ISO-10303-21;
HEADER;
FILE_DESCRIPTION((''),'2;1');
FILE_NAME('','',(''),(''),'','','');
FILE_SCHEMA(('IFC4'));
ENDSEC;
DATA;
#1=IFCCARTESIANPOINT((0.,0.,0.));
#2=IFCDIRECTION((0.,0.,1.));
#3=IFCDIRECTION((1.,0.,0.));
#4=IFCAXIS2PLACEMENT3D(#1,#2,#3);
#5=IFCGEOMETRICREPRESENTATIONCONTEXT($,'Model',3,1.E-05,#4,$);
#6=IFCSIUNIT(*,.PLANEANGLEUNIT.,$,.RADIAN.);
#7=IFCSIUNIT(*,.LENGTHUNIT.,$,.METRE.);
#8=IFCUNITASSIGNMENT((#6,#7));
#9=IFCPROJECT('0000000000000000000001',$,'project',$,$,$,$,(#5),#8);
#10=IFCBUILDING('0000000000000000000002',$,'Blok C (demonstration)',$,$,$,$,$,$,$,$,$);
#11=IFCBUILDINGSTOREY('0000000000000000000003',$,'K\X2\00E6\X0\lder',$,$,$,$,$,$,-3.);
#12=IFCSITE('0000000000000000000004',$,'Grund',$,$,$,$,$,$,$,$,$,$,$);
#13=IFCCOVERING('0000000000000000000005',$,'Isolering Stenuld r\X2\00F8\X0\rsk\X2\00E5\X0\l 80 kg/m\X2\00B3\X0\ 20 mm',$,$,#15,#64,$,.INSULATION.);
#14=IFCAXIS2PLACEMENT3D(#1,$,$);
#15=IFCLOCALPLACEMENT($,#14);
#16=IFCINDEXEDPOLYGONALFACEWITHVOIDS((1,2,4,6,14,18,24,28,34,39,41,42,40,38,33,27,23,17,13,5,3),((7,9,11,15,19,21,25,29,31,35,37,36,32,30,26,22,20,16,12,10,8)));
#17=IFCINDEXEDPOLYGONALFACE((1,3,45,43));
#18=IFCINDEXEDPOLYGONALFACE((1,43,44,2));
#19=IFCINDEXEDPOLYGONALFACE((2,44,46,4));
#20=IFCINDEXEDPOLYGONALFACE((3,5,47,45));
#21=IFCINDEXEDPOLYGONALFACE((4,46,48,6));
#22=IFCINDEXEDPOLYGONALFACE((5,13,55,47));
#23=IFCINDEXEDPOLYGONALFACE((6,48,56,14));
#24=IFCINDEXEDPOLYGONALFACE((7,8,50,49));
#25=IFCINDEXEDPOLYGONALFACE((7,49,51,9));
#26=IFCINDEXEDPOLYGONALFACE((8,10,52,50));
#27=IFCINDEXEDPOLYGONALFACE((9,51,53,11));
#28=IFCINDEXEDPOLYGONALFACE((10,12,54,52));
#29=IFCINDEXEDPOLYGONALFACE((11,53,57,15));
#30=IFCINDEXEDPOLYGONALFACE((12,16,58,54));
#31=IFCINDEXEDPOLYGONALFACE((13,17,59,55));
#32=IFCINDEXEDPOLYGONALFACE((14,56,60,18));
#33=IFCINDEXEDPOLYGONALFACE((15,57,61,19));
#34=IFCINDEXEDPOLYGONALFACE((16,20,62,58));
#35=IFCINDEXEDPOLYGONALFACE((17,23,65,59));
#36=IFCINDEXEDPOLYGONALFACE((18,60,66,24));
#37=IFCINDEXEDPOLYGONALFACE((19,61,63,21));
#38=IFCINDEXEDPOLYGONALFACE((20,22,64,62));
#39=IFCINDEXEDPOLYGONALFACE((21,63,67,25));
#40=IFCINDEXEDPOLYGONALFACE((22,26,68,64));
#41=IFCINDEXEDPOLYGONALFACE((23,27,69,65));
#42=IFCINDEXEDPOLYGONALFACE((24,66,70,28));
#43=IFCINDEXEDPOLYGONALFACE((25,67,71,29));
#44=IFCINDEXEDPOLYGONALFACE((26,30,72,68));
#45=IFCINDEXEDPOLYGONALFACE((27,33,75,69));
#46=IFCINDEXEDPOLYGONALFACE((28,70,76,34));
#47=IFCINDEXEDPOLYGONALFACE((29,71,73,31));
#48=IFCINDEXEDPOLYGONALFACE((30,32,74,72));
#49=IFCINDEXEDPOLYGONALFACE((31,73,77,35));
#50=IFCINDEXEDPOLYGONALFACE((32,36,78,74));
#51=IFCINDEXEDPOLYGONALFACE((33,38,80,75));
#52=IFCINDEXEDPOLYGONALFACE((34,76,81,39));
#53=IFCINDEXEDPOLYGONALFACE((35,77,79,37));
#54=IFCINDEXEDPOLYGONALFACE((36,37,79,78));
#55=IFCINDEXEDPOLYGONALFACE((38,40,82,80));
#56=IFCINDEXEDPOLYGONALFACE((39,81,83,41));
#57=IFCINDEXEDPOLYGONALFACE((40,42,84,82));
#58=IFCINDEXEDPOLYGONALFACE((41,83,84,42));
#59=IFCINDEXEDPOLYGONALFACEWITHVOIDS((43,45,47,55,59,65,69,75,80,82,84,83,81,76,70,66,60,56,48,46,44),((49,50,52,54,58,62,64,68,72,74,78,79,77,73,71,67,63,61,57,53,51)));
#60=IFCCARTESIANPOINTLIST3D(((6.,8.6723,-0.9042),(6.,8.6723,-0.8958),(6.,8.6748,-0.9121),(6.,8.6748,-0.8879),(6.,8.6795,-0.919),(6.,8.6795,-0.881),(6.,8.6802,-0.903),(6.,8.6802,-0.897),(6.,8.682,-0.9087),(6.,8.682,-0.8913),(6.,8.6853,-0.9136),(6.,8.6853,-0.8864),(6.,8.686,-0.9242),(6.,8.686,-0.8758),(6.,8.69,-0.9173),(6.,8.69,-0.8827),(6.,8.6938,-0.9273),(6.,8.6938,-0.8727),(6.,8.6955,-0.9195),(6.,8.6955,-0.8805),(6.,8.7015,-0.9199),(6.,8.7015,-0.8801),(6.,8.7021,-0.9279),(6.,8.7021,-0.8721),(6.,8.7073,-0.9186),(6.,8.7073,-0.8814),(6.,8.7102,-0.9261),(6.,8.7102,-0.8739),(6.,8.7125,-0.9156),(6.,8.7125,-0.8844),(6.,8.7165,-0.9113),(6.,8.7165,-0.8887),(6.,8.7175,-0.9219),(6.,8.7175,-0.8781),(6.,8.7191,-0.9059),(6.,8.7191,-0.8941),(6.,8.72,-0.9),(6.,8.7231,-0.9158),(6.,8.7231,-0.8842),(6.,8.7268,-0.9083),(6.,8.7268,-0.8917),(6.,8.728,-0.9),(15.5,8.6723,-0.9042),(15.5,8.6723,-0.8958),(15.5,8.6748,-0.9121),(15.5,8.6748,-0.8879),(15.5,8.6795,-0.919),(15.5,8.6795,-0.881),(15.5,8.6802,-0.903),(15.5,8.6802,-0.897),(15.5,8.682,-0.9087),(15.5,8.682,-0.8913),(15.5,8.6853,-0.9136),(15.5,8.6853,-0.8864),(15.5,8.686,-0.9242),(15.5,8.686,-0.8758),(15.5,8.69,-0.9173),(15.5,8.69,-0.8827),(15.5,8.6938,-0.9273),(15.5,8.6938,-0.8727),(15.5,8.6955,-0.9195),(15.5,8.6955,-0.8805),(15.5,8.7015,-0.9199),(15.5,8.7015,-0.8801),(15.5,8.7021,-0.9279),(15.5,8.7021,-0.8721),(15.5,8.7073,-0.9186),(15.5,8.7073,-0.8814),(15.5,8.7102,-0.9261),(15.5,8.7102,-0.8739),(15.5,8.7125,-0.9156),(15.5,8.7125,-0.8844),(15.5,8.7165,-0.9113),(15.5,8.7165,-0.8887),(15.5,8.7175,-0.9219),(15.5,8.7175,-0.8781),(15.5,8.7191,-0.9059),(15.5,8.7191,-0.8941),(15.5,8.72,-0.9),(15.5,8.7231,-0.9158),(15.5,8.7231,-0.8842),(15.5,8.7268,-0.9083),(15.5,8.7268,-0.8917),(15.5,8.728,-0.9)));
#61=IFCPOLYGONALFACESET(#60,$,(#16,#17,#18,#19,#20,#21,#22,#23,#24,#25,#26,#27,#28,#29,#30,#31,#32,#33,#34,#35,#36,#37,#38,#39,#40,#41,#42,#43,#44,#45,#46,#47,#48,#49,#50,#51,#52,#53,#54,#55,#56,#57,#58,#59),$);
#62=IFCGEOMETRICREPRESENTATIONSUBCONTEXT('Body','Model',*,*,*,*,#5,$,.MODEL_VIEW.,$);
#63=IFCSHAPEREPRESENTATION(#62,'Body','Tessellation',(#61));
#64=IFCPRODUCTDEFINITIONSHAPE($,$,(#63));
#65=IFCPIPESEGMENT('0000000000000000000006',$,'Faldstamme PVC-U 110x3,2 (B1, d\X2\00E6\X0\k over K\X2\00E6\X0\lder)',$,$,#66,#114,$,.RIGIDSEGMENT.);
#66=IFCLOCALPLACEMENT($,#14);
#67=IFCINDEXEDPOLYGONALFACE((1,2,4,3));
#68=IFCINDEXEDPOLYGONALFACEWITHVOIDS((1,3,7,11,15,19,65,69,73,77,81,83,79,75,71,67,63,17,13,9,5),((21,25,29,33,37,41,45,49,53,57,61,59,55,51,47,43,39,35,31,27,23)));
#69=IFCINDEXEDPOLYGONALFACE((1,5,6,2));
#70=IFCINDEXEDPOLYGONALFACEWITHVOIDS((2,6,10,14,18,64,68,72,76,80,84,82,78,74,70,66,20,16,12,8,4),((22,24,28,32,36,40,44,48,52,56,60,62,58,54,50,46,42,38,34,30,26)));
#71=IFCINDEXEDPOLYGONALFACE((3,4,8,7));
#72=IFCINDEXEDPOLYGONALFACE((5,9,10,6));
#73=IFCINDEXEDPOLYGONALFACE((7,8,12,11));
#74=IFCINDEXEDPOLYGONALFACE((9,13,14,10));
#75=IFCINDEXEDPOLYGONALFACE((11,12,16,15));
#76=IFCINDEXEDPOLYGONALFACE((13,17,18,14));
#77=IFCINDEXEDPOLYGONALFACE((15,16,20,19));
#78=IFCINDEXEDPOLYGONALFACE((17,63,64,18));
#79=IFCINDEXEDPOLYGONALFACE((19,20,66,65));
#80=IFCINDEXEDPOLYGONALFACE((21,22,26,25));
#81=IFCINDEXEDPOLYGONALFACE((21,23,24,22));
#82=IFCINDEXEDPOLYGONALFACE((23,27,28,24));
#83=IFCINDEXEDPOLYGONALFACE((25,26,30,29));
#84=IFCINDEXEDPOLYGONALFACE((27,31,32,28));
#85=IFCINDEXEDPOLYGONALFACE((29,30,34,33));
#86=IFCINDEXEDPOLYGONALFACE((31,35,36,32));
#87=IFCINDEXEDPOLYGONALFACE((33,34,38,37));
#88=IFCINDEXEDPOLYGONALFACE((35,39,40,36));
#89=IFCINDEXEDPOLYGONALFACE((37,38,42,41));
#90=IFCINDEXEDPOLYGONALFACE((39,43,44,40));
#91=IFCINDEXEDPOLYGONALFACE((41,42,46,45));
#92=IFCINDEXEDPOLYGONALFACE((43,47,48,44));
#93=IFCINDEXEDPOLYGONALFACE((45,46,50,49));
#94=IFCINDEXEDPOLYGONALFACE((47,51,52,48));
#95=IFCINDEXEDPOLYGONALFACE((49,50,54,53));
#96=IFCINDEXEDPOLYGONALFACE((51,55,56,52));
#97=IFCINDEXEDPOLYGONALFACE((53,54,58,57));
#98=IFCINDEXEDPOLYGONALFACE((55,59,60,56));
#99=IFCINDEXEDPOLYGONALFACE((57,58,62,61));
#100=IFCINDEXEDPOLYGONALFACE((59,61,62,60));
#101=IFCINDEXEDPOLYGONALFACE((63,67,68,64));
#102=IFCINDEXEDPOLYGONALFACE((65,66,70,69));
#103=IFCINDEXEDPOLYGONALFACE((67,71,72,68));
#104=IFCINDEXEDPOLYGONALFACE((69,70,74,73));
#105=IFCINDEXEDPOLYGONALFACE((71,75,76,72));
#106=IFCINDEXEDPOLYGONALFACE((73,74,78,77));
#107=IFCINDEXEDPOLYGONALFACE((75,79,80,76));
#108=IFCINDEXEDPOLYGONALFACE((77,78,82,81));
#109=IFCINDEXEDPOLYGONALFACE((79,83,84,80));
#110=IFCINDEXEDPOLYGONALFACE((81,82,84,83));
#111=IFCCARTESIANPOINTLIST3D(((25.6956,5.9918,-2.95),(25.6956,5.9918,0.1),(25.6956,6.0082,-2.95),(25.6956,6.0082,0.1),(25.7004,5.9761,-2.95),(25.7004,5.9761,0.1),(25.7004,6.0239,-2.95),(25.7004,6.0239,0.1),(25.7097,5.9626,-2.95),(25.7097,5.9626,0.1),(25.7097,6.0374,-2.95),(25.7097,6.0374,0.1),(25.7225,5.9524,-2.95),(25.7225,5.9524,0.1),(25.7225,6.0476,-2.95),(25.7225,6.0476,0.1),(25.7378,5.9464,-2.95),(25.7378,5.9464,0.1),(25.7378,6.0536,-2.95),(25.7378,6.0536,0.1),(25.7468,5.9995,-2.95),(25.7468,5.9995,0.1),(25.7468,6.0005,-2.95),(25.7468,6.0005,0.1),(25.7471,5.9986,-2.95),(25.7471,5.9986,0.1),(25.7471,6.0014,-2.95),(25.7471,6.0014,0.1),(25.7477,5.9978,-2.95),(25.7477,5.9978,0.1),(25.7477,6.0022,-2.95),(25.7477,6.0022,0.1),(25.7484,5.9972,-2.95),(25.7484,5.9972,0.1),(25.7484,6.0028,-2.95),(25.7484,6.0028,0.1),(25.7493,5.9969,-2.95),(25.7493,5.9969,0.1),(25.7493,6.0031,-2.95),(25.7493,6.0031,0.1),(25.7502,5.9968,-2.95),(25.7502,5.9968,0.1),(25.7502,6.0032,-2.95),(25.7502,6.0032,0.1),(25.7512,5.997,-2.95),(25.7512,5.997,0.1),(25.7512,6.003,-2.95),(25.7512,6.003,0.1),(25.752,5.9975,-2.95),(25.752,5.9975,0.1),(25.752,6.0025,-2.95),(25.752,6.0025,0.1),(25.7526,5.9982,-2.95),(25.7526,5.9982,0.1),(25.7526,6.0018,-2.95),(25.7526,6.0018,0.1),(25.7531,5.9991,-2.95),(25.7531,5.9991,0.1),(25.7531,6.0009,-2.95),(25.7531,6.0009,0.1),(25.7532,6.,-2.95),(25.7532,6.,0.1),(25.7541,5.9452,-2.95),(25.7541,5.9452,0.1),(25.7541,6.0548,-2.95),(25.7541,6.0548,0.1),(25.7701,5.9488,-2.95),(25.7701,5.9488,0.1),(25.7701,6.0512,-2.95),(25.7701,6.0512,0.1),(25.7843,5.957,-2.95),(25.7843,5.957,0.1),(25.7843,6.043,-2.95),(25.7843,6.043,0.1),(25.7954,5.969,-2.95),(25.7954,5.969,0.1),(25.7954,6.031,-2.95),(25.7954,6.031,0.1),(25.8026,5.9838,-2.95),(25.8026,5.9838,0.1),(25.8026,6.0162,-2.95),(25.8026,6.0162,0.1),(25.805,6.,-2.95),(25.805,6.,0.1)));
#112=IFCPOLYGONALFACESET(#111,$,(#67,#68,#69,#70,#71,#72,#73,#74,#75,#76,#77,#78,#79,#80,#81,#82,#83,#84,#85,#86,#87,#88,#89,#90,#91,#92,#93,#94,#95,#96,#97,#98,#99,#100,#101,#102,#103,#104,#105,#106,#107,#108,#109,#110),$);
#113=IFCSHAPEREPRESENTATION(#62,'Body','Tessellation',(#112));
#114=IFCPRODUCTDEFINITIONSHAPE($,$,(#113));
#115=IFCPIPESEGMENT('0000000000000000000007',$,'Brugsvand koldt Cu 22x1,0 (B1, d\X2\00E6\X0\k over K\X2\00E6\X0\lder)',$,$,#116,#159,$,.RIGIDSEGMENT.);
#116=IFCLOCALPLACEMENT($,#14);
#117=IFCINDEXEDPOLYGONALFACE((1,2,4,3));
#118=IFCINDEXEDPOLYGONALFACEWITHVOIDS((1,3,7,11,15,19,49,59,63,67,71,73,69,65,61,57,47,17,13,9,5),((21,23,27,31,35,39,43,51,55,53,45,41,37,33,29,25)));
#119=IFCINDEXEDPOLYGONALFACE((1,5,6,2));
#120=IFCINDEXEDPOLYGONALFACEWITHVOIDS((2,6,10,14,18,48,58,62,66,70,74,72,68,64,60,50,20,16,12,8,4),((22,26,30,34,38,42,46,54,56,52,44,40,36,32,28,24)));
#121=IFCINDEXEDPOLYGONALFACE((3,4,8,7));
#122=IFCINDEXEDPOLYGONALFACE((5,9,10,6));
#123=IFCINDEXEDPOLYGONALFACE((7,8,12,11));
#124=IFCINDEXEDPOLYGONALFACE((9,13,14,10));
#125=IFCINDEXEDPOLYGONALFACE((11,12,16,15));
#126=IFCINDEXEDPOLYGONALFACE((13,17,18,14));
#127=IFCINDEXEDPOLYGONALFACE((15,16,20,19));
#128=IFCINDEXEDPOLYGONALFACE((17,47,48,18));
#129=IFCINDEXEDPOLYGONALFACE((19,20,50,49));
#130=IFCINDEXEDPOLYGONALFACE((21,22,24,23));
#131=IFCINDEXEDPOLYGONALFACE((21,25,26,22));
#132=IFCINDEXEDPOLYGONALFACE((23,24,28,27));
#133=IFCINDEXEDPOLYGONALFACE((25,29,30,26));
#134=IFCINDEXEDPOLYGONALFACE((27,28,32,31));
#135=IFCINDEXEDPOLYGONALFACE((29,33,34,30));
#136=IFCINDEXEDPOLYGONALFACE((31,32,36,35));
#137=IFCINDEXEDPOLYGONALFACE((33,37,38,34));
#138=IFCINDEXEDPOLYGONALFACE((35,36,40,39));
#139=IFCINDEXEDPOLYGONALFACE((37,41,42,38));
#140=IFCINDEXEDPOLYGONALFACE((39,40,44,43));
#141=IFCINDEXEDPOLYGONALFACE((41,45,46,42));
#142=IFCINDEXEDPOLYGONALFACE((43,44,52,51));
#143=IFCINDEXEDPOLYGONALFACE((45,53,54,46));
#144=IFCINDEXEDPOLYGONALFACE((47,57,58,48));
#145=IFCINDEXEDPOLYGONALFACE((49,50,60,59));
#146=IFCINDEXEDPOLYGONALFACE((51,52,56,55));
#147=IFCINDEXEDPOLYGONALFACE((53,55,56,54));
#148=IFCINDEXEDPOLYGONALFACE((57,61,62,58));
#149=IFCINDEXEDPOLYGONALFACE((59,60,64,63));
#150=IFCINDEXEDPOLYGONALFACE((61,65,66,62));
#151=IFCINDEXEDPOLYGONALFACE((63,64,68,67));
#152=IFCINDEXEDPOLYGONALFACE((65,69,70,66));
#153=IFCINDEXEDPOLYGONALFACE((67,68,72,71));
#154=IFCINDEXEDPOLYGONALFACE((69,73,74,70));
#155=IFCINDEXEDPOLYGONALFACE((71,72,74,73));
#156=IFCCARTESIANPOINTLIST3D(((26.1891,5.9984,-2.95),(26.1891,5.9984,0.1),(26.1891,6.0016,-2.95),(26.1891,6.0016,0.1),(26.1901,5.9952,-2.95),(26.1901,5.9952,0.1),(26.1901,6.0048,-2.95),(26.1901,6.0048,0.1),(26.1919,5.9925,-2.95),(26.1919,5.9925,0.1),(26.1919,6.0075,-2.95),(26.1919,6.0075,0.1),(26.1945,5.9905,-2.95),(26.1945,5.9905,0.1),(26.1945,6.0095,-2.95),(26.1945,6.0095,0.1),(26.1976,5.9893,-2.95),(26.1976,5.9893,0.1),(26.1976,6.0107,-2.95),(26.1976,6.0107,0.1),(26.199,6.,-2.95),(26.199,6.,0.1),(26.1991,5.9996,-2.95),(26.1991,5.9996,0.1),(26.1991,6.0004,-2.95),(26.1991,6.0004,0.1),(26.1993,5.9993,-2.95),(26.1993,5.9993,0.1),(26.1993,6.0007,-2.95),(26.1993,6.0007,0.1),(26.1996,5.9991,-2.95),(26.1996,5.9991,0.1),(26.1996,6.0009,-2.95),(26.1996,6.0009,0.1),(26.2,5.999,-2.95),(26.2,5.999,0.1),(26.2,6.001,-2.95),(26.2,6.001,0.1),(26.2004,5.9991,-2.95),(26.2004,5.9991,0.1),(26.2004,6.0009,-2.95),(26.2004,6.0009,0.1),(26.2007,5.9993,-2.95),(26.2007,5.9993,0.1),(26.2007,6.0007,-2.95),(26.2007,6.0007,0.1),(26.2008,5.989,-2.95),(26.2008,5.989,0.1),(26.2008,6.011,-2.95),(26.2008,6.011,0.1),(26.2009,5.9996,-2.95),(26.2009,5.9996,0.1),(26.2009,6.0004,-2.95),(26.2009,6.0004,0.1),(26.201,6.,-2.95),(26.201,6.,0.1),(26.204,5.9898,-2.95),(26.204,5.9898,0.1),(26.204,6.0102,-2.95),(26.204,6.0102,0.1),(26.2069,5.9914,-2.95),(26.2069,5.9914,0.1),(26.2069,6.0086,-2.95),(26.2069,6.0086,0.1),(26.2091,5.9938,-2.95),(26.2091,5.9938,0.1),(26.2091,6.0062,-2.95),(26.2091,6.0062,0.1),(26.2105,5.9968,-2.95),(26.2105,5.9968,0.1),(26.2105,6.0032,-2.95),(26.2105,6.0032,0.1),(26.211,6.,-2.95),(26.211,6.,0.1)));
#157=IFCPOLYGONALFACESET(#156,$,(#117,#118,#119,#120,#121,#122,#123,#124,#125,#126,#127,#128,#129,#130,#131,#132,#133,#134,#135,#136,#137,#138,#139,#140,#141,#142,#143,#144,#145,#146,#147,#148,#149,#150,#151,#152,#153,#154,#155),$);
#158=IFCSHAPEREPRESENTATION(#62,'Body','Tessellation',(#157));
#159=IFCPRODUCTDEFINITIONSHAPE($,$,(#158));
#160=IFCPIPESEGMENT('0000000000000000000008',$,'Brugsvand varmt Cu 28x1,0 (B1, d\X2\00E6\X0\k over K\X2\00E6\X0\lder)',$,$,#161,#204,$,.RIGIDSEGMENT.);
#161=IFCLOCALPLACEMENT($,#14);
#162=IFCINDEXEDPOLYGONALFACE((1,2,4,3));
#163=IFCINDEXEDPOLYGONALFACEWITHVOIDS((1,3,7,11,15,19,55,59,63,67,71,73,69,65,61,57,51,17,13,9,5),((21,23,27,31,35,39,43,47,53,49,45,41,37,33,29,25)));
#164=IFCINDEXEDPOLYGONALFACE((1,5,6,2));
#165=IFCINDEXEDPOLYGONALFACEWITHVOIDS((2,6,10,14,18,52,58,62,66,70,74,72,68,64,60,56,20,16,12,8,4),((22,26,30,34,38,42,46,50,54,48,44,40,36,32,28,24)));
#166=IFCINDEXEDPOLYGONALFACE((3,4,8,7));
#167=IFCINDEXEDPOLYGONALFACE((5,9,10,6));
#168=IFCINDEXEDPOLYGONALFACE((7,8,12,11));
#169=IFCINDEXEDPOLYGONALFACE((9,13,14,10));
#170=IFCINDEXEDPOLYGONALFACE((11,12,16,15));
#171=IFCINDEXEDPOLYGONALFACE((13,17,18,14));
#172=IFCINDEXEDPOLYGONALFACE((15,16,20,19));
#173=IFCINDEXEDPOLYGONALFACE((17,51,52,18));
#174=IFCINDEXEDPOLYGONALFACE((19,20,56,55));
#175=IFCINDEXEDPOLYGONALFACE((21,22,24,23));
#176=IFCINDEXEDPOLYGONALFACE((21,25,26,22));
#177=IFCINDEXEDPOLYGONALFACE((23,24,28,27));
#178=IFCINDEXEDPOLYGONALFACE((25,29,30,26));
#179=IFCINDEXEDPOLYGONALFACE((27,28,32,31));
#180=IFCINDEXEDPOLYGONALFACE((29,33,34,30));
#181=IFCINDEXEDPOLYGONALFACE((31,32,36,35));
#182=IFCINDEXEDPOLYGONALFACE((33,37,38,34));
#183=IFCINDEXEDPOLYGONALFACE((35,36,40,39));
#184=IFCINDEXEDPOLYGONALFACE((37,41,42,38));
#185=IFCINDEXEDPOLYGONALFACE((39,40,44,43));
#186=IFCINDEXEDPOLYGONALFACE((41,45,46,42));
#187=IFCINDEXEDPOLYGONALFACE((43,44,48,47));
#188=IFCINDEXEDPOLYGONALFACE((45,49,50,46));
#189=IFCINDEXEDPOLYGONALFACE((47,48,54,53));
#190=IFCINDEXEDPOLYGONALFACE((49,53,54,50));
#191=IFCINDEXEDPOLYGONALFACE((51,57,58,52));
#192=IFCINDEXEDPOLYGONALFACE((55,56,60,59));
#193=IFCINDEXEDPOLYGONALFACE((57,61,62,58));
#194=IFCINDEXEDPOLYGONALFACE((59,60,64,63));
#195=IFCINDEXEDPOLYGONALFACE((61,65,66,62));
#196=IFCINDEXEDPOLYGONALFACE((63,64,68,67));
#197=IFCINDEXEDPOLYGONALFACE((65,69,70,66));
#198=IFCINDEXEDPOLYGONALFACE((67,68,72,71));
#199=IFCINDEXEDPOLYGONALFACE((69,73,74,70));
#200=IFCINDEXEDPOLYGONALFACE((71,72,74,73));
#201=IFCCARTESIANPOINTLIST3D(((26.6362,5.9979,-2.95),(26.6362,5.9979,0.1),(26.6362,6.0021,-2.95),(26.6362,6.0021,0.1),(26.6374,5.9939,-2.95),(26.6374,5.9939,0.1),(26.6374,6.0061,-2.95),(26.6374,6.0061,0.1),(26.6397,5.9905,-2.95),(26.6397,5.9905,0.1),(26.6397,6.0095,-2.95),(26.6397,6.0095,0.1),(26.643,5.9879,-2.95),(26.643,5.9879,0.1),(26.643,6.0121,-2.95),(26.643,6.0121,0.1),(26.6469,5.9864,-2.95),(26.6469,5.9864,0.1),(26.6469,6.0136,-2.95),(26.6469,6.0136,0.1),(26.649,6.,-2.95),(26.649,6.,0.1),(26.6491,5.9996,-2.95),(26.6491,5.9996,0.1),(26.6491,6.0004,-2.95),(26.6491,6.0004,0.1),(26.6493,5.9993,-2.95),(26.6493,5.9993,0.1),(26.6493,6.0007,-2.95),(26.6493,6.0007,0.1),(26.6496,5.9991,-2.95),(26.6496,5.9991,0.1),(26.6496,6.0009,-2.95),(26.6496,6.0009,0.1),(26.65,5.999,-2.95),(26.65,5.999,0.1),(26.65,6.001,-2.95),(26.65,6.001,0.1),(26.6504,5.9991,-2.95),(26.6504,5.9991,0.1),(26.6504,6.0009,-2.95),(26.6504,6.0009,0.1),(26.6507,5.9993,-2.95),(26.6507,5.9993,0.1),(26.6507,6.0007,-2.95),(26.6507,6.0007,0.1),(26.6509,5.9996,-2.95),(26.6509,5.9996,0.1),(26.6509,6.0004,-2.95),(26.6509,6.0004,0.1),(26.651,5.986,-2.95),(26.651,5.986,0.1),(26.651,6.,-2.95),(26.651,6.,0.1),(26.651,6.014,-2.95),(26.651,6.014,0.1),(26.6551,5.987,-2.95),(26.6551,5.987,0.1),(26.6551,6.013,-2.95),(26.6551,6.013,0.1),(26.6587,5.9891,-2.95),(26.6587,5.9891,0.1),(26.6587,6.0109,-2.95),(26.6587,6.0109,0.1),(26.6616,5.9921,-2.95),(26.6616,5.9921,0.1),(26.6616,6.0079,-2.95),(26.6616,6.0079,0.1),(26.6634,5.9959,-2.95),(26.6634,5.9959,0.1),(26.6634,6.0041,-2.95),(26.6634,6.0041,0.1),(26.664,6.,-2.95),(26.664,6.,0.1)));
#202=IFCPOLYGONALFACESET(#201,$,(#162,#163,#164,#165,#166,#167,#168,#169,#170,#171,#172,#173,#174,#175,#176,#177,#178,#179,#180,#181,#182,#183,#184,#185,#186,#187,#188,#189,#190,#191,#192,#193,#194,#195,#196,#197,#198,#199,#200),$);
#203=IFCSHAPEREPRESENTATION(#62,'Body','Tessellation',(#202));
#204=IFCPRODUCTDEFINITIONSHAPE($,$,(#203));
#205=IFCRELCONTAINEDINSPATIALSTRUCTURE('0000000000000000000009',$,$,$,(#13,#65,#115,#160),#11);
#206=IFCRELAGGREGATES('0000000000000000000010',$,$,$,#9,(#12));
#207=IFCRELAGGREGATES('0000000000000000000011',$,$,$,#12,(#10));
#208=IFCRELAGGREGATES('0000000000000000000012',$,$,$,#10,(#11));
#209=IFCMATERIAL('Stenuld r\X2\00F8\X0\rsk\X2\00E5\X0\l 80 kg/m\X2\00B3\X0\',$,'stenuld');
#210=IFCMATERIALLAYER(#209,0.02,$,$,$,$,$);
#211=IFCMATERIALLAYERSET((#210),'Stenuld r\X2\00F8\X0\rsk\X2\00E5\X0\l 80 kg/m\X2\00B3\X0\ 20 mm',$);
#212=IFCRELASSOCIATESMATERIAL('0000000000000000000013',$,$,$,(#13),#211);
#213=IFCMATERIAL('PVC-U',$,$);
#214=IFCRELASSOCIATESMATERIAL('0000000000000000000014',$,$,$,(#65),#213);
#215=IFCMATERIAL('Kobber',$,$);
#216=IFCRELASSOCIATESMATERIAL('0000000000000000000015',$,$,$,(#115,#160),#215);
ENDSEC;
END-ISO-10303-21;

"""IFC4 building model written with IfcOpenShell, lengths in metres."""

from ifc_helpers import new_model, si_unit, frame, origin_with_axes, place, context, subcontext, project, spatial, hollow_circle, extrude, material, layer, layer_set, element, save


model = new_model("IFC4")

# Units and contexts
model_context = context("Model", 3, precision=1e-05, world=origin_with_axes())
body_context = subcontext(model_context, "Body", "Model", "MODEL_VIEW")
ifc_project = project(units=[si_unit("PLANEANGLEUNIT", "RADIAN"), si_unit("LENGTHUNIT", "METRE")], contexts=[model_context])

# Site, building, storey
site = spatial("IfcSite", under=ifc_project, Name="Grund")
building = spatial("IfcBuilding", under=site, Name="Blok C (demonstration)")
storey = spatial("IfcBuildingStorey", under=building, Name="Kælder", Elevation=-3.0)

# Covering
ifc_material_1 = material(Name="Stenuld rørskål 80 kg/m³", Category="stenuld")
ifc_layer_1 = layer(ifc_material_1, 0.02)
ifc_layer_set_1 = layer_set([ifc_layer_1], Name="Stenuld rørskål 80 kg/m³ 20 mm")
covering_1_placement = place(None, origin_with_axes())
element("IfcCovering", 1, at=covering_1_placement, inside=storey, material=ifc_layer_set_1, Name="Isolering Stenuld rørskål 80 kg/m³ 20 mm", PredefinedType="INSULATION", context=body_context, shape_type="SweptSolid", body=[
    extrude(hollow_circle(Radius=0.028, WallThickness=0.008), frame((6.0, 8.7, -0.9), z_axis=(1.0, 0.0, 0.0), x_axis=(0.0, 1.0, 0.0)), (0.0, 0.0, 1.0), 9.5),
])

# Pipe segments
ifc_material_2 = material(Name="PVC-U")
pipe_segment_1_placement = place(None, origin_with_axes())
element("IfcPipeSegment", 2, at=pipe_segment_1_placement, inside=storey, material=ifc_material_2, Name="Faldstamme PVC-U 110x3,2 (B1, dæk over Kælder)", PredefinedType="RIGIDSEGMENT", context=body_context, shape_type="SweptSolid", body=[
    extrude(hollow_circle(Radius=0.055, WallThickness=0.0518), frame((25.75, 6.0, -2.95), z_axis=(0.0, 0.0, 1.0), x_axis=(1.0, 0.0, 0.0)), (0.0, 0.0, 1.0), 3.05),
])
ifc_material_3 = material(Name="Kobber")
pipe_segment_2_placement = place(None, origin_with_axes())
element("IfcPipeSegment", 3, at=pipe_segment_2_placement, inside=storey, material=ifc_material_3, Name="Brugsvand koldt Cu 22x1,0 (B1, dæk over Kælder)", PredefinedType="RIGIDSEGMENT", context=body_context, shape_type="SweptSolid", body=[
    extrude(hollow_circle(Radius=0.011, WallThickness=0.01), frame((26.2, 6.0, -2.95), z_axis=(0.0, 0.0, 1.0), x_axis=(1.0, 0.0, 0.0)), (0.0, 0.0, 1.0), 3.05),
])
pipe_segment_3_placement = place(None, origin_with_axes())
element("IfcPipeSegment", 4, at=pipe_segment_3_placement, inside=storey, material=ifc_material_3, Name="Brugsvand varmt Cu 28x1,0 (B1, dæk over Kælder)", PredefinedType="RIGIDSEGMENT", context=body_context, shape_type="SweptSolid", body=[
    extrude(hollow_circle(Radius=0.014, WallThickness=0.013), frame((26.65, 6.0, -2.95), z_axis=(0.0, 0.0, 1.0), x_axis=(1.0, 0.0, 0.0)), (0.0, 0.0, 1.0), 3.05),
])

save(model, "model.ifc")
